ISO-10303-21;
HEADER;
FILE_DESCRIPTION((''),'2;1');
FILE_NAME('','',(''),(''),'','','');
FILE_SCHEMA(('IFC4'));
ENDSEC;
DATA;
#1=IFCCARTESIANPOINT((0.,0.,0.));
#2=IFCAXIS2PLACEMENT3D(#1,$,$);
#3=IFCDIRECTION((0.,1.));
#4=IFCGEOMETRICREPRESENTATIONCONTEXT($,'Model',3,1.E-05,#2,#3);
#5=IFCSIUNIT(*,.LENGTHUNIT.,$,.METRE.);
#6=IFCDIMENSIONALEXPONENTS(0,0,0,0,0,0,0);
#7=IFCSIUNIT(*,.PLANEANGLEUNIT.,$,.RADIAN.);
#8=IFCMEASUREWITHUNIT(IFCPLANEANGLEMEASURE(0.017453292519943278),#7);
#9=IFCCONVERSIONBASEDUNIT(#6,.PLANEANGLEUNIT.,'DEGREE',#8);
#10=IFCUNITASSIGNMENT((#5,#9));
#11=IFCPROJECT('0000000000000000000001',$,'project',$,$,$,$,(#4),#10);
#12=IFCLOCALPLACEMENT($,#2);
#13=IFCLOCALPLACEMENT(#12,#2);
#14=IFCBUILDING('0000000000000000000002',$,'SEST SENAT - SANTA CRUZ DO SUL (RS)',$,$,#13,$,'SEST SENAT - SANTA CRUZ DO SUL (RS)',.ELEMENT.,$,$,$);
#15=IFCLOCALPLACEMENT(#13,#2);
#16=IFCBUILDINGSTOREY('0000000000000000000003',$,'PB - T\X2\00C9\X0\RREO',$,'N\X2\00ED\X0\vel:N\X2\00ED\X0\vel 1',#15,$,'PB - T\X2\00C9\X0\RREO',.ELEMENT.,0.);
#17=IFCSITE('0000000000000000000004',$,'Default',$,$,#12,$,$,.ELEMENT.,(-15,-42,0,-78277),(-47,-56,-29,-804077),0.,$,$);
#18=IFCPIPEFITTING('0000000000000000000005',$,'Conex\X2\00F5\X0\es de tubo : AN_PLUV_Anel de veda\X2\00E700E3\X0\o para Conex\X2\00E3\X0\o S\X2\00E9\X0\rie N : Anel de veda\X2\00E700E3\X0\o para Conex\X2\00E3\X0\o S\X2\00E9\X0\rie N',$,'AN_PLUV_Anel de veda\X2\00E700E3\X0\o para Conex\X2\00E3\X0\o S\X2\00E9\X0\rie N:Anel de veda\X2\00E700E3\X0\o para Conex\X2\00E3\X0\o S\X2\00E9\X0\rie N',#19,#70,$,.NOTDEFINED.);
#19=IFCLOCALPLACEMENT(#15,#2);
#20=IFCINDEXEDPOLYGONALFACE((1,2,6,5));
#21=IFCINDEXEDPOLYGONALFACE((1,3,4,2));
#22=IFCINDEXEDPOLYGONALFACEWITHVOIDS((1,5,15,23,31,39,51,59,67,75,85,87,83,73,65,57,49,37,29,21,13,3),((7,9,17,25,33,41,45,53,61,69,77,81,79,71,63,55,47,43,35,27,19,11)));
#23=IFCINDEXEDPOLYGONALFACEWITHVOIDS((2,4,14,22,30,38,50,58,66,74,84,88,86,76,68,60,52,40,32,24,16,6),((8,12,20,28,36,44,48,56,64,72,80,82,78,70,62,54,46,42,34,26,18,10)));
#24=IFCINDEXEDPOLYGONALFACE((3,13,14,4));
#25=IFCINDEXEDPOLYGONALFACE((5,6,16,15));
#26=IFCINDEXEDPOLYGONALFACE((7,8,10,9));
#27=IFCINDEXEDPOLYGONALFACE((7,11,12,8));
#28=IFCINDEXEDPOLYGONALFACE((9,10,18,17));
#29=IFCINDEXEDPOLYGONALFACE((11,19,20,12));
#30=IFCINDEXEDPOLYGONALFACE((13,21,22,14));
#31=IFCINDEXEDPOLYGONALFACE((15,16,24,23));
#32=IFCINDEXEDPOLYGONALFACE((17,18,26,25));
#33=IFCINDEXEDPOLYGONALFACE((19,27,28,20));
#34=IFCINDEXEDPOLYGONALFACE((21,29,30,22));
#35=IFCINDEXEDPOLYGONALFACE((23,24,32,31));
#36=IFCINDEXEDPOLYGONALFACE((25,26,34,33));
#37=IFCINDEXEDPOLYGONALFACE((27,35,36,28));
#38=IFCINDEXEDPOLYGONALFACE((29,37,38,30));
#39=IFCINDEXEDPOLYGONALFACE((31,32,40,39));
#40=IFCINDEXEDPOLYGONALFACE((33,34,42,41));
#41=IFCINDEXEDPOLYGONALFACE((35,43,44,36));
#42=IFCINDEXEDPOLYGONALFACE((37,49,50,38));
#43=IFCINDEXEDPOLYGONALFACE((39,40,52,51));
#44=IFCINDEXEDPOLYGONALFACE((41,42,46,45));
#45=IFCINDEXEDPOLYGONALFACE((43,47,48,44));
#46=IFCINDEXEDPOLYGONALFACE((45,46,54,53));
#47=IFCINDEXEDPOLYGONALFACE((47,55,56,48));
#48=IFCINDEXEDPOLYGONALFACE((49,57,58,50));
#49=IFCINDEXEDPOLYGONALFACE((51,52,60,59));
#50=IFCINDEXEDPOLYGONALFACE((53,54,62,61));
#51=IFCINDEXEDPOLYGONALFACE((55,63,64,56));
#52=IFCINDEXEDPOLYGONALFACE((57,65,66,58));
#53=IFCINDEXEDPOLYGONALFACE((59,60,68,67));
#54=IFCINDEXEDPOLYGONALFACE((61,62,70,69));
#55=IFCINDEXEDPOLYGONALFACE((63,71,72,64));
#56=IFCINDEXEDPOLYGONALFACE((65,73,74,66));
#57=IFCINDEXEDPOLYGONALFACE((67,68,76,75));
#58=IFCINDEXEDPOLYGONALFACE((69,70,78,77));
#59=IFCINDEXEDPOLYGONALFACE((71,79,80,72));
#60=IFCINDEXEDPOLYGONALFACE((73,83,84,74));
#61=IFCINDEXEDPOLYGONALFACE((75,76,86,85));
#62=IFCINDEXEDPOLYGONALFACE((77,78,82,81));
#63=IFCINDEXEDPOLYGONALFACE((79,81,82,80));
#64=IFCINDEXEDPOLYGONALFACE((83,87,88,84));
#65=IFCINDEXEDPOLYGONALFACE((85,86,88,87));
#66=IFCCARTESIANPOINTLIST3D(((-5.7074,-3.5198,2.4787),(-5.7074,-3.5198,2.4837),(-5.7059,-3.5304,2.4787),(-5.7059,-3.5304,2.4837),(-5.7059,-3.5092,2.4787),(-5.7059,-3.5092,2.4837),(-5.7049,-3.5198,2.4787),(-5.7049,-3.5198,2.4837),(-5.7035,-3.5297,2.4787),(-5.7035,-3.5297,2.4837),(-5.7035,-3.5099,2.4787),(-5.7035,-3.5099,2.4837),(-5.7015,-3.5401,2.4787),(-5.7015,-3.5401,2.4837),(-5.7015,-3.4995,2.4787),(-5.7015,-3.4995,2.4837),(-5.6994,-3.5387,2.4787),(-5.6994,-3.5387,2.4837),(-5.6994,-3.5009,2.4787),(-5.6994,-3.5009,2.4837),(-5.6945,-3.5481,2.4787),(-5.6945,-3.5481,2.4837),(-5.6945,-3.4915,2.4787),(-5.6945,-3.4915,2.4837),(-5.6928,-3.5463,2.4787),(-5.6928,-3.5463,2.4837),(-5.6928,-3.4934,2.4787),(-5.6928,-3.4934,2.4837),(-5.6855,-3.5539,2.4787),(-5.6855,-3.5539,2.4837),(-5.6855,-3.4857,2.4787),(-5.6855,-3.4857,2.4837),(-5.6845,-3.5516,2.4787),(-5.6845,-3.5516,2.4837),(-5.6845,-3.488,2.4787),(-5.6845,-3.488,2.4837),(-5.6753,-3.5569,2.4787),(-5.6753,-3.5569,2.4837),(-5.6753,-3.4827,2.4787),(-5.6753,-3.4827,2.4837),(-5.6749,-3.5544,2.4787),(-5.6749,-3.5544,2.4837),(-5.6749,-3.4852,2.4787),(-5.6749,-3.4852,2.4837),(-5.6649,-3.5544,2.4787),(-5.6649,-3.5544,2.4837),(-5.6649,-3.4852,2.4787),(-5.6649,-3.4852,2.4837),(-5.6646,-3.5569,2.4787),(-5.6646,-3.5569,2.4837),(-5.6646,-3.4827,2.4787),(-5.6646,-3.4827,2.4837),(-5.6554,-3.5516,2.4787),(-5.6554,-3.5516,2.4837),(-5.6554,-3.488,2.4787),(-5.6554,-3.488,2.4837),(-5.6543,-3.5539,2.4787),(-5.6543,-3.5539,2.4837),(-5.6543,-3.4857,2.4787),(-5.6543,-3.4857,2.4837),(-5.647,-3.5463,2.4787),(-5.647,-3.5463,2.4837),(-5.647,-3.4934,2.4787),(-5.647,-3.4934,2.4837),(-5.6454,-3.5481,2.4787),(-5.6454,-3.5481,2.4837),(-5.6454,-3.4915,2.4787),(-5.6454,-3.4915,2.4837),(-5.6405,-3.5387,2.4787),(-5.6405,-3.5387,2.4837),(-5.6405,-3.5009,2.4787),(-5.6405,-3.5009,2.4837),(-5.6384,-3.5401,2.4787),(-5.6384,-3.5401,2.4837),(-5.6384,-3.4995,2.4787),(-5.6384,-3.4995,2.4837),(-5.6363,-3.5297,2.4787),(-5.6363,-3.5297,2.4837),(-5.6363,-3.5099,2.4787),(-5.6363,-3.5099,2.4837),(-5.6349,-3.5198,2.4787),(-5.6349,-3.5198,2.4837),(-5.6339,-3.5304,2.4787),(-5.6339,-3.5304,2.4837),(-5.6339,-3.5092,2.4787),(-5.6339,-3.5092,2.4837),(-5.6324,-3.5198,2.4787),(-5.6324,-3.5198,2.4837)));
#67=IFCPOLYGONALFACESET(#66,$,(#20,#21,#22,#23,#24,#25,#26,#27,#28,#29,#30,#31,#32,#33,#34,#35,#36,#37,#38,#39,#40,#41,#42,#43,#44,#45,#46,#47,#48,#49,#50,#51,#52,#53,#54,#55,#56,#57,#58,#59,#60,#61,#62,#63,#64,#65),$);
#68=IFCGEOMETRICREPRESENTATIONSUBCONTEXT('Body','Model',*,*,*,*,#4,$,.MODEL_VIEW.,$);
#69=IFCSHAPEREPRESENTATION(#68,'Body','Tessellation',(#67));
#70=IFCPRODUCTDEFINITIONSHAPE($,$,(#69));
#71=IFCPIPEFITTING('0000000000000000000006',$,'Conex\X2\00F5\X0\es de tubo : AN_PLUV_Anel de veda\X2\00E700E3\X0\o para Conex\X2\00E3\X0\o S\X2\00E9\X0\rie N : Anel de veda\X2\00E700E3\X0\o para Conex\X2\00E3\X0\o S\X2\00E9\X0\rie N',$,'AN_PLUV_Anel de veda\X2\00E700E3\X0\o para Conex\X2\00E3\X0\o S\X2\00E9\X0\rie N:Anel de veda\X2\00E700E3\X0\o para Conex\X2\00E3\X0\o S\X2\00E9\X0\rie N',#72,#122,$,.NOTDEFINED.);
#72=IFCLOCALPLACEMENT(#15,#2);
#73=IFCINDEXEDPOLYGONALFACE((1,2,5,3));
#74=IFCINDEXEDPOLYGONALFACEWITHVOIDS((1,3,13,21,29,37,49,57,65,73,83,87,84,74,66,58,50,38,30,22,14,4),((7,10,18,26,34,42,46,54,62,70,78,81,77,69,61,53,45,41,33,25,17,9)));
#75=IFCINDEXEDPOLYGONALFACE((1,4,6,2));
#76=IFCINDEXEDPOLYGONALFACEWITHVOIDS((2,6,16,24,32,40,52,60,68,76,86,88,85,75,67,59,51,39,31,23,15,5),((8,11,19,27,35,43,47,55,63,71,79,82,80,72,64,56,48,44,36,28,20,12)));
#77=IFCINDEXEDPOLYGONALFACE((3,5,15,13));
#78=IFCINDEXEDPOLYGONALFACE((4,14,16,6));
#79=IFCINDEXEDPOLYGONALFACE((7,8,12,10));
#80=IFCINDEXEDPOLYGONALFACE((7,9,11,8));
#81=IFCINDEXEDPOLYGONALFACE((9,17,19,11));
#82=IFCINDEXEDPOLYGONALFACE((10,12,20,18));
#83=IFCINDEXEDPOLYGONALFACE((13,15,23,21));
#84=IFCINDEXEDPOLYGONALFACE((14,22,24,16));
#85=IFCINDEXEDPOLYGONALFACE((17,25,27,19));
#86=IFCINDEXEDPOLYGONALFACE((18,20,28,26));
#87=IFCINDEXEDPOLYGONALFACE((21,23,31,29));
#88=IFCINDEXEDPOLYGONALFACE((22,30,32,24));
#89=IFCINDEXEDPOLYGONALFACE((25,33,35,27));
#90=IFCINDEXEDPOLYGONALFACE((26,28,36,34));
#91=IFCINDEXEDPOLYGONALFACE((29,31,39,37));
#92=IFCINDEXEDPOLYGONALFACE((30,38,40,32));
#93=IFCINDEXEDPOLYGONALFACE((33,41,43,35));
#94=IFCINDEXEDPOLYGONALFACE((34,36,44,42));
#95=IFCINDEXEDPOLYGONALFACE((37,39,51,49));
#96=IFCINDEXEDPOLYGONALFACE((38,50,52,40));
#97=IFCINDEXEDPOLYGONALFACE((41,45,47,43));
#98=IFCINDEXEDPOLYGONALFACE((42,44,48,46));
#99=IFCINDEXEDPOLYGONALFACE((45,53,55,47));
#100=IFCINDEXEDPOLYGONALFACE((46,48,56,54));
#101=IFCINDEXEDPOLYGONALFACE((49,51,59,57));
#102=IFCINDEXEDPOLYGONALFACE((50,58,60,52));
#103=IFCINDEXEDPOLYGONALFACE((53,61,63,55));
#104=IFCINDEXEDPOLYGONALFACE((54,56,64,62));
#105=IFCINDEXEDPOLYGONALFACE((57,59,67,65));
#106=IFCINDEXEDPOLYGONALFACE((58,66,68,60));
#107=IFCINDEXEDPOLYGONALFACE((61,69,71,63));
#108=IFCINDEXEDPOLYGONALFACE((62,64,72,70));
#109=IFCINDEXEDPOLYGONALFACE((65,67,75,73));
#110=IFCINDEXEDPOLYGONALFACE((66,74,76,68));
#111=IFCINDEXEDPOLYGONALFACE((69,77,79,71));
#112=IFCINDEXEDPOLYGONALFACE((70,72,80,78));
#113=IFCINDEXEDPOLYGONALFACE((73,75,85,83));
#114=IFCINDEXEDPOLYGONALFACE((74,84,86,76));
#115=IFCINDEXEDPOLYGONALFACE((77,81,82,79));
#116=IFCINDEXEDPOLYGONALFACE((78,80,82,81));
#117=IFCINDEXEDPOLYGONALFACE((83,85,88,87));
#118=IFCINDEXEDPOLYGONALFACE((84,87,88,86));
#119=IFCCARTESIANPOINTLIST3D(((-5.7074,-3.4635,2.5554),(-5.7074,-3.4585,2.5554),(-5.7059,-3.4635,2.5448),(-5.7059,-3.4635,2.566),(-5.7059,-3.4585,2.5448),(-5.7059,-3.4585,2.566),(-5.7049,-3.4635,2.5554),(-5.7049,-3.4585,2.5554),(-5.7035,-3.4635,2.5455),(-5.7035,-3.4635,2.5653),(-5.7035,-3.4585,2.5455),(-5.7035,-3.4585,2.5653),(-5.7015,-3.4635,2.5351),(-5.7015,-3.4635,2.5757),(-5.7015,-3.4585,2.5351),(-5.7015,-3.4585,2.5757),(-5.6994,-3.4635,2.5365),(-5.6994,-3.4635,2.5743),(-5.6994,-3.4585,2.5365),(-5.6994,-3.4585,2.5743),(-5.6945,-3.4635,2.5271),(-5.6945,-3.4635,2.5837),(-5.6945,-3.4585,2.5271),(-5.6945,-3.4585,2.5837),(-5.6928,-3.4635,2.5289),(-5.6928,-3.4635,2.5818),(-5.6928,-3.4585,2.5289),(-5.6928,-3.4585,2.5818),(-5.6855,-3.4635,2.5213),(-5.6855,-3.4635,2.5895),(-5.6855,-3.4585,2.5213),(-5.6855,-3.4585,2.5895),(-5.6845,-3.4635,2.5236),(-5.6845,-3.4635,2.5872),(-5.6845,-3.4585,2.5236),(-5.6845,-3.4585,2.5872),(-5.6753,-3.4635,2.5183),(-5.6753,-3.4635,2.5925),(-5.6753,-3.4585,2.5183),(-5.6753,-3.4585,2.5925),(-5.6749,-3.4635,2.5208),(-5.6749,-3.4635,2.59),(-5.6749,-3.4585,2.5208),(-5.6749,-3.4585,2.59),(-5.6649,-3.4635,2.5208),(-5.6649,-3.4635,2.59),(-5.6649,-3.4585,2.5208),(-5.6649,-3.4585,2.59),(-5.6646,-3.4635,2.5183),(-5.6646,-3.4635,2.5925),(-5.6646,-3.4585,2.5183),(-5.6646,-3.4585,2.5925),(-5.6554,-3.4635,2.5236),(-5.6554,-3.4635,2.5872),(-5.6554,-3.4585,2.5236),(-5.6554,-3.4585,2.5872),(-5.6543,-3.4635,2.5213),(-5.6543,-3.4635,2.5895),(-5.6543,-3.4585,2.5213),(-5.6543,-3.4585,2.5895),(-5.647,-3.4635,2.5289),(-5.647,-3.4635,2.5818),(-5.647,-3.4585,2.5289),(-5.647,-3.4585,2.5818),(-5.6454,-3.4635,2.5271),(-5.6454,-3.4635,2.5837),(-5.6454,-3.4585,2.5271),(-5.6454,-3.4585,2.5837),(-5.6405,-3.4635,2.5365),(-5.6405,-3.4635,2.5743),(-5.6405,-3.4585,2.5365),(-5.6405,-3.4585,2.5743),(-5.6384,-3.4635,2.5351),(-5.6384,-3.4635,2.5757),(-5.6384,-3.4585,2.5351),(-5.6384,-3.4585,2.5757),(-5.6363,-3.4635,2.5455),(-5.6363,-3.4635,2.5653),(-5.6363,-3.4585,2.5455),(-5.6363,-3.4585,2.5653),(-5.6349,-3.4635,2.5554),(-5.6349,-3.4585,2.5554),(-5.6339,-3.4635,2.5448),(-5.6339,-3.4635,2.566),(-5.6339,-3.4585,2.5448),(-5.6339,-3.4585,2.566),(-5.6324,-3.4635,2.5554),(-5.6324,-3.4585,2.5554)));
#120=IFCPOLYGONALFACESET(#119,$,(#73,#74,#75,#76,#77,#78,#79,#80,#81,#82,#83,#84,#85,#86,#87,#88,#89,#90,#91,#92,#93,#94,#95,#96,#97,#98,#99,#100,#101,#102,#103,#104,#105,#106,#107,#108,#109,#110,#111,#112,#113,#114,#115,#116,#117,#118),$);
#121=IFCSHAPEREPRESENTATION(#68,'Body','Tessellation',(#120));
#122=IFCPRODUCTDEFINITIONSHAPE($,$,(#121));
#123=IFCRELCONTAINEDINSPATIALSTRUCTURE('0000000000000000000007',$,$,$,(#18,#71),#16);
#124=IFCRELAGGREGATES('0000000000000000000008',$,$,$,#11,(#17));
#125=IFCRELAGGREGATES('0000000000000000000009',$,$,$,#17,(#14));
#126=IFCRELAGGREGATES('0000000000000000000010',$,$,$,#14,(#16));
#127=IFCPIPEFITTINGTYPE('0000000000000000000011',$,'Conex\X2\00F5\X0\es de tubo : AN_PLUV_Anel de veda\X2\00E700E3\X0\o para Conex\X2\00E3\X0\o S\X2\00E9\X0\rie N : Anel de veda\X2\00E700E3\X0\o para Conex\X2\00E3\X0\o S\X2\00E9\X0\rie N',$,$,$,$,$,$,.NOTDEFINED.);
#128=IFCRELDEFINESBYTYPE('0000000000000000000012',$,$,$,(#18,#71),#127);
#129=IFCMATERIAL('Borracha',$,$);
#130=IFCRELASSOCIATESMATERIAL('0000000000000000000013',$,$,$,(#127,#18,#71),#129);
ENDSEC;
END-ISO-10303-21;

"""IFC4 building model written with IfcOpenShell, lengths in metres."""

from ifc_helpers import new_model, entity, si_unit, converted_unit, direction, frame, origin, place, context, subcontext, project, spatial, arc, indexed_curve, outline, extrude, source, transform, mapped, material, type_object, type_shapes, element, save


model = new_model("IFC4")

# Units and contexts
model_context = context("Model", 3, precision=1e-05, world=origin(), true_north=direction((0.0, 1.0)))
body_context = subcontext(model_context, "Body", "Model", "MODEL_VIEW")
ifc_project = project(units=[si_unit("LENGTHUNIT", "METRE"), converted_unit("PLANEANGLEUNIT", "DEGREE", entity("IfcPlaneAngleMeasure", 0.017453292519943278), si_unit("PLANEANGLEUNIT", "RADIAN"), dimensions=[0, 0, 0, 0, 0, 0, 0])], contexts=[model_context])

# Site, building, storey
site_placement = place(None, origin())
site = spatial("IfcSite", under=ifc_project, at=site_placement, Name="Default", CompositionType="ELEMENT", RefLatitude=(-15, -42, 0, -78277), RefLongitude=(-47, -56, -29, -804077), RefElevation=0.0)
building_placement = place(site_placement, origin())
building = spatial("IfcBuilding", under=site, at=building_placement, Name="SEST SENAT - SANTA CRUZ DO SUL (RS)", LongName="SEST SENAT - SANTA CRUZ DO SUL (RS)", CompositionType="ELEMENT")
storey_placement = place(building_placement, origin())
storey = spatial("IfcBuildingStorey", under=building, at=storey_placement, Name="PB - TÉRREO", ObjectType="Nível:Nível 1", LongName="PB - TÉRREO", CompositionType="ELEMENT", Elevation=0.0)

# Shared definitions
ifc_material_1 = material(Name="Borracha")

# Pipe fittings
pipe_fitting_type_1 = type_object("IfcPipeFittingType", Name="Conexões de tubo : AN_PLUV_Anel de vedação para Conexão Série N : Anel de vedação para Conexão Série N", PredefinedType="NOTDEFINED", material=ifc_material_1)
shared_shape_1 = source(origin(), body_context, "Body", "SweptSolid", [
    extrude(outline(indexed_curve([(-0.0375, 0.0), (0.0, -0.0375), (0.0375, 0.0), (0.0, 0.0375)], segments=[arc(1, 2, 3), arc(3, 4, 1)], self_intersect=False), holes=[indexed_curve([(-0.035, 0.0), (0.0, 0.035), (0.035, 0.0), (0.0, -0.035)], segments=[arc(1, 2, 3), arc(3, 4, 1)], self_intersect=False)]), frame((0.0, 0.0, -0.005)), (0.0, 0.0, 1.0), 0.005),
])
type_shapes(pipe_fitting_type_1, [shared_shape_1])
for number, where, z_axis, x_axis, name in (
    (1, (-5.6699, -3.5198, 2.4787), (0.0, 0.0, -1.0), (-1.0, 0.0, 0.0), "Conexões de tubo : AN_PLUV_Anel de vedação para Conexão Série N : Anel de vedação para Conexão Série N"),
    (2, (-5.6699, -3.4635, 2.5554), (0.0, -1.0, 0.0), (-1.0, 0.0, 0.0), "Conexões de tubo : AN_PLUV_Anel de vedação para Conexão Série N : Anel de vedação para Conexão Série N"),
):
    element("IfcPipeFitting", number, at=place(storey_placement, frame(where, z_axis=z_axis, x_axis=x_axis)), inside=storey, type_object=pipe_fitting_type_1, material=ifc_material_1, Name=name, ObjectType="AN_PLUV_Anel de vedação para Conexão Série N:Anel de vedação para Conexão Série N", PredefinedType="NOTDEFINED", context=body_context, shape_type="MappedRepresentation", body=[
        mapped(shared_shape_1, transform((0.0, 0.0, 0.0), scale=1.0)),
    ])

save(model, "model.ifc")
